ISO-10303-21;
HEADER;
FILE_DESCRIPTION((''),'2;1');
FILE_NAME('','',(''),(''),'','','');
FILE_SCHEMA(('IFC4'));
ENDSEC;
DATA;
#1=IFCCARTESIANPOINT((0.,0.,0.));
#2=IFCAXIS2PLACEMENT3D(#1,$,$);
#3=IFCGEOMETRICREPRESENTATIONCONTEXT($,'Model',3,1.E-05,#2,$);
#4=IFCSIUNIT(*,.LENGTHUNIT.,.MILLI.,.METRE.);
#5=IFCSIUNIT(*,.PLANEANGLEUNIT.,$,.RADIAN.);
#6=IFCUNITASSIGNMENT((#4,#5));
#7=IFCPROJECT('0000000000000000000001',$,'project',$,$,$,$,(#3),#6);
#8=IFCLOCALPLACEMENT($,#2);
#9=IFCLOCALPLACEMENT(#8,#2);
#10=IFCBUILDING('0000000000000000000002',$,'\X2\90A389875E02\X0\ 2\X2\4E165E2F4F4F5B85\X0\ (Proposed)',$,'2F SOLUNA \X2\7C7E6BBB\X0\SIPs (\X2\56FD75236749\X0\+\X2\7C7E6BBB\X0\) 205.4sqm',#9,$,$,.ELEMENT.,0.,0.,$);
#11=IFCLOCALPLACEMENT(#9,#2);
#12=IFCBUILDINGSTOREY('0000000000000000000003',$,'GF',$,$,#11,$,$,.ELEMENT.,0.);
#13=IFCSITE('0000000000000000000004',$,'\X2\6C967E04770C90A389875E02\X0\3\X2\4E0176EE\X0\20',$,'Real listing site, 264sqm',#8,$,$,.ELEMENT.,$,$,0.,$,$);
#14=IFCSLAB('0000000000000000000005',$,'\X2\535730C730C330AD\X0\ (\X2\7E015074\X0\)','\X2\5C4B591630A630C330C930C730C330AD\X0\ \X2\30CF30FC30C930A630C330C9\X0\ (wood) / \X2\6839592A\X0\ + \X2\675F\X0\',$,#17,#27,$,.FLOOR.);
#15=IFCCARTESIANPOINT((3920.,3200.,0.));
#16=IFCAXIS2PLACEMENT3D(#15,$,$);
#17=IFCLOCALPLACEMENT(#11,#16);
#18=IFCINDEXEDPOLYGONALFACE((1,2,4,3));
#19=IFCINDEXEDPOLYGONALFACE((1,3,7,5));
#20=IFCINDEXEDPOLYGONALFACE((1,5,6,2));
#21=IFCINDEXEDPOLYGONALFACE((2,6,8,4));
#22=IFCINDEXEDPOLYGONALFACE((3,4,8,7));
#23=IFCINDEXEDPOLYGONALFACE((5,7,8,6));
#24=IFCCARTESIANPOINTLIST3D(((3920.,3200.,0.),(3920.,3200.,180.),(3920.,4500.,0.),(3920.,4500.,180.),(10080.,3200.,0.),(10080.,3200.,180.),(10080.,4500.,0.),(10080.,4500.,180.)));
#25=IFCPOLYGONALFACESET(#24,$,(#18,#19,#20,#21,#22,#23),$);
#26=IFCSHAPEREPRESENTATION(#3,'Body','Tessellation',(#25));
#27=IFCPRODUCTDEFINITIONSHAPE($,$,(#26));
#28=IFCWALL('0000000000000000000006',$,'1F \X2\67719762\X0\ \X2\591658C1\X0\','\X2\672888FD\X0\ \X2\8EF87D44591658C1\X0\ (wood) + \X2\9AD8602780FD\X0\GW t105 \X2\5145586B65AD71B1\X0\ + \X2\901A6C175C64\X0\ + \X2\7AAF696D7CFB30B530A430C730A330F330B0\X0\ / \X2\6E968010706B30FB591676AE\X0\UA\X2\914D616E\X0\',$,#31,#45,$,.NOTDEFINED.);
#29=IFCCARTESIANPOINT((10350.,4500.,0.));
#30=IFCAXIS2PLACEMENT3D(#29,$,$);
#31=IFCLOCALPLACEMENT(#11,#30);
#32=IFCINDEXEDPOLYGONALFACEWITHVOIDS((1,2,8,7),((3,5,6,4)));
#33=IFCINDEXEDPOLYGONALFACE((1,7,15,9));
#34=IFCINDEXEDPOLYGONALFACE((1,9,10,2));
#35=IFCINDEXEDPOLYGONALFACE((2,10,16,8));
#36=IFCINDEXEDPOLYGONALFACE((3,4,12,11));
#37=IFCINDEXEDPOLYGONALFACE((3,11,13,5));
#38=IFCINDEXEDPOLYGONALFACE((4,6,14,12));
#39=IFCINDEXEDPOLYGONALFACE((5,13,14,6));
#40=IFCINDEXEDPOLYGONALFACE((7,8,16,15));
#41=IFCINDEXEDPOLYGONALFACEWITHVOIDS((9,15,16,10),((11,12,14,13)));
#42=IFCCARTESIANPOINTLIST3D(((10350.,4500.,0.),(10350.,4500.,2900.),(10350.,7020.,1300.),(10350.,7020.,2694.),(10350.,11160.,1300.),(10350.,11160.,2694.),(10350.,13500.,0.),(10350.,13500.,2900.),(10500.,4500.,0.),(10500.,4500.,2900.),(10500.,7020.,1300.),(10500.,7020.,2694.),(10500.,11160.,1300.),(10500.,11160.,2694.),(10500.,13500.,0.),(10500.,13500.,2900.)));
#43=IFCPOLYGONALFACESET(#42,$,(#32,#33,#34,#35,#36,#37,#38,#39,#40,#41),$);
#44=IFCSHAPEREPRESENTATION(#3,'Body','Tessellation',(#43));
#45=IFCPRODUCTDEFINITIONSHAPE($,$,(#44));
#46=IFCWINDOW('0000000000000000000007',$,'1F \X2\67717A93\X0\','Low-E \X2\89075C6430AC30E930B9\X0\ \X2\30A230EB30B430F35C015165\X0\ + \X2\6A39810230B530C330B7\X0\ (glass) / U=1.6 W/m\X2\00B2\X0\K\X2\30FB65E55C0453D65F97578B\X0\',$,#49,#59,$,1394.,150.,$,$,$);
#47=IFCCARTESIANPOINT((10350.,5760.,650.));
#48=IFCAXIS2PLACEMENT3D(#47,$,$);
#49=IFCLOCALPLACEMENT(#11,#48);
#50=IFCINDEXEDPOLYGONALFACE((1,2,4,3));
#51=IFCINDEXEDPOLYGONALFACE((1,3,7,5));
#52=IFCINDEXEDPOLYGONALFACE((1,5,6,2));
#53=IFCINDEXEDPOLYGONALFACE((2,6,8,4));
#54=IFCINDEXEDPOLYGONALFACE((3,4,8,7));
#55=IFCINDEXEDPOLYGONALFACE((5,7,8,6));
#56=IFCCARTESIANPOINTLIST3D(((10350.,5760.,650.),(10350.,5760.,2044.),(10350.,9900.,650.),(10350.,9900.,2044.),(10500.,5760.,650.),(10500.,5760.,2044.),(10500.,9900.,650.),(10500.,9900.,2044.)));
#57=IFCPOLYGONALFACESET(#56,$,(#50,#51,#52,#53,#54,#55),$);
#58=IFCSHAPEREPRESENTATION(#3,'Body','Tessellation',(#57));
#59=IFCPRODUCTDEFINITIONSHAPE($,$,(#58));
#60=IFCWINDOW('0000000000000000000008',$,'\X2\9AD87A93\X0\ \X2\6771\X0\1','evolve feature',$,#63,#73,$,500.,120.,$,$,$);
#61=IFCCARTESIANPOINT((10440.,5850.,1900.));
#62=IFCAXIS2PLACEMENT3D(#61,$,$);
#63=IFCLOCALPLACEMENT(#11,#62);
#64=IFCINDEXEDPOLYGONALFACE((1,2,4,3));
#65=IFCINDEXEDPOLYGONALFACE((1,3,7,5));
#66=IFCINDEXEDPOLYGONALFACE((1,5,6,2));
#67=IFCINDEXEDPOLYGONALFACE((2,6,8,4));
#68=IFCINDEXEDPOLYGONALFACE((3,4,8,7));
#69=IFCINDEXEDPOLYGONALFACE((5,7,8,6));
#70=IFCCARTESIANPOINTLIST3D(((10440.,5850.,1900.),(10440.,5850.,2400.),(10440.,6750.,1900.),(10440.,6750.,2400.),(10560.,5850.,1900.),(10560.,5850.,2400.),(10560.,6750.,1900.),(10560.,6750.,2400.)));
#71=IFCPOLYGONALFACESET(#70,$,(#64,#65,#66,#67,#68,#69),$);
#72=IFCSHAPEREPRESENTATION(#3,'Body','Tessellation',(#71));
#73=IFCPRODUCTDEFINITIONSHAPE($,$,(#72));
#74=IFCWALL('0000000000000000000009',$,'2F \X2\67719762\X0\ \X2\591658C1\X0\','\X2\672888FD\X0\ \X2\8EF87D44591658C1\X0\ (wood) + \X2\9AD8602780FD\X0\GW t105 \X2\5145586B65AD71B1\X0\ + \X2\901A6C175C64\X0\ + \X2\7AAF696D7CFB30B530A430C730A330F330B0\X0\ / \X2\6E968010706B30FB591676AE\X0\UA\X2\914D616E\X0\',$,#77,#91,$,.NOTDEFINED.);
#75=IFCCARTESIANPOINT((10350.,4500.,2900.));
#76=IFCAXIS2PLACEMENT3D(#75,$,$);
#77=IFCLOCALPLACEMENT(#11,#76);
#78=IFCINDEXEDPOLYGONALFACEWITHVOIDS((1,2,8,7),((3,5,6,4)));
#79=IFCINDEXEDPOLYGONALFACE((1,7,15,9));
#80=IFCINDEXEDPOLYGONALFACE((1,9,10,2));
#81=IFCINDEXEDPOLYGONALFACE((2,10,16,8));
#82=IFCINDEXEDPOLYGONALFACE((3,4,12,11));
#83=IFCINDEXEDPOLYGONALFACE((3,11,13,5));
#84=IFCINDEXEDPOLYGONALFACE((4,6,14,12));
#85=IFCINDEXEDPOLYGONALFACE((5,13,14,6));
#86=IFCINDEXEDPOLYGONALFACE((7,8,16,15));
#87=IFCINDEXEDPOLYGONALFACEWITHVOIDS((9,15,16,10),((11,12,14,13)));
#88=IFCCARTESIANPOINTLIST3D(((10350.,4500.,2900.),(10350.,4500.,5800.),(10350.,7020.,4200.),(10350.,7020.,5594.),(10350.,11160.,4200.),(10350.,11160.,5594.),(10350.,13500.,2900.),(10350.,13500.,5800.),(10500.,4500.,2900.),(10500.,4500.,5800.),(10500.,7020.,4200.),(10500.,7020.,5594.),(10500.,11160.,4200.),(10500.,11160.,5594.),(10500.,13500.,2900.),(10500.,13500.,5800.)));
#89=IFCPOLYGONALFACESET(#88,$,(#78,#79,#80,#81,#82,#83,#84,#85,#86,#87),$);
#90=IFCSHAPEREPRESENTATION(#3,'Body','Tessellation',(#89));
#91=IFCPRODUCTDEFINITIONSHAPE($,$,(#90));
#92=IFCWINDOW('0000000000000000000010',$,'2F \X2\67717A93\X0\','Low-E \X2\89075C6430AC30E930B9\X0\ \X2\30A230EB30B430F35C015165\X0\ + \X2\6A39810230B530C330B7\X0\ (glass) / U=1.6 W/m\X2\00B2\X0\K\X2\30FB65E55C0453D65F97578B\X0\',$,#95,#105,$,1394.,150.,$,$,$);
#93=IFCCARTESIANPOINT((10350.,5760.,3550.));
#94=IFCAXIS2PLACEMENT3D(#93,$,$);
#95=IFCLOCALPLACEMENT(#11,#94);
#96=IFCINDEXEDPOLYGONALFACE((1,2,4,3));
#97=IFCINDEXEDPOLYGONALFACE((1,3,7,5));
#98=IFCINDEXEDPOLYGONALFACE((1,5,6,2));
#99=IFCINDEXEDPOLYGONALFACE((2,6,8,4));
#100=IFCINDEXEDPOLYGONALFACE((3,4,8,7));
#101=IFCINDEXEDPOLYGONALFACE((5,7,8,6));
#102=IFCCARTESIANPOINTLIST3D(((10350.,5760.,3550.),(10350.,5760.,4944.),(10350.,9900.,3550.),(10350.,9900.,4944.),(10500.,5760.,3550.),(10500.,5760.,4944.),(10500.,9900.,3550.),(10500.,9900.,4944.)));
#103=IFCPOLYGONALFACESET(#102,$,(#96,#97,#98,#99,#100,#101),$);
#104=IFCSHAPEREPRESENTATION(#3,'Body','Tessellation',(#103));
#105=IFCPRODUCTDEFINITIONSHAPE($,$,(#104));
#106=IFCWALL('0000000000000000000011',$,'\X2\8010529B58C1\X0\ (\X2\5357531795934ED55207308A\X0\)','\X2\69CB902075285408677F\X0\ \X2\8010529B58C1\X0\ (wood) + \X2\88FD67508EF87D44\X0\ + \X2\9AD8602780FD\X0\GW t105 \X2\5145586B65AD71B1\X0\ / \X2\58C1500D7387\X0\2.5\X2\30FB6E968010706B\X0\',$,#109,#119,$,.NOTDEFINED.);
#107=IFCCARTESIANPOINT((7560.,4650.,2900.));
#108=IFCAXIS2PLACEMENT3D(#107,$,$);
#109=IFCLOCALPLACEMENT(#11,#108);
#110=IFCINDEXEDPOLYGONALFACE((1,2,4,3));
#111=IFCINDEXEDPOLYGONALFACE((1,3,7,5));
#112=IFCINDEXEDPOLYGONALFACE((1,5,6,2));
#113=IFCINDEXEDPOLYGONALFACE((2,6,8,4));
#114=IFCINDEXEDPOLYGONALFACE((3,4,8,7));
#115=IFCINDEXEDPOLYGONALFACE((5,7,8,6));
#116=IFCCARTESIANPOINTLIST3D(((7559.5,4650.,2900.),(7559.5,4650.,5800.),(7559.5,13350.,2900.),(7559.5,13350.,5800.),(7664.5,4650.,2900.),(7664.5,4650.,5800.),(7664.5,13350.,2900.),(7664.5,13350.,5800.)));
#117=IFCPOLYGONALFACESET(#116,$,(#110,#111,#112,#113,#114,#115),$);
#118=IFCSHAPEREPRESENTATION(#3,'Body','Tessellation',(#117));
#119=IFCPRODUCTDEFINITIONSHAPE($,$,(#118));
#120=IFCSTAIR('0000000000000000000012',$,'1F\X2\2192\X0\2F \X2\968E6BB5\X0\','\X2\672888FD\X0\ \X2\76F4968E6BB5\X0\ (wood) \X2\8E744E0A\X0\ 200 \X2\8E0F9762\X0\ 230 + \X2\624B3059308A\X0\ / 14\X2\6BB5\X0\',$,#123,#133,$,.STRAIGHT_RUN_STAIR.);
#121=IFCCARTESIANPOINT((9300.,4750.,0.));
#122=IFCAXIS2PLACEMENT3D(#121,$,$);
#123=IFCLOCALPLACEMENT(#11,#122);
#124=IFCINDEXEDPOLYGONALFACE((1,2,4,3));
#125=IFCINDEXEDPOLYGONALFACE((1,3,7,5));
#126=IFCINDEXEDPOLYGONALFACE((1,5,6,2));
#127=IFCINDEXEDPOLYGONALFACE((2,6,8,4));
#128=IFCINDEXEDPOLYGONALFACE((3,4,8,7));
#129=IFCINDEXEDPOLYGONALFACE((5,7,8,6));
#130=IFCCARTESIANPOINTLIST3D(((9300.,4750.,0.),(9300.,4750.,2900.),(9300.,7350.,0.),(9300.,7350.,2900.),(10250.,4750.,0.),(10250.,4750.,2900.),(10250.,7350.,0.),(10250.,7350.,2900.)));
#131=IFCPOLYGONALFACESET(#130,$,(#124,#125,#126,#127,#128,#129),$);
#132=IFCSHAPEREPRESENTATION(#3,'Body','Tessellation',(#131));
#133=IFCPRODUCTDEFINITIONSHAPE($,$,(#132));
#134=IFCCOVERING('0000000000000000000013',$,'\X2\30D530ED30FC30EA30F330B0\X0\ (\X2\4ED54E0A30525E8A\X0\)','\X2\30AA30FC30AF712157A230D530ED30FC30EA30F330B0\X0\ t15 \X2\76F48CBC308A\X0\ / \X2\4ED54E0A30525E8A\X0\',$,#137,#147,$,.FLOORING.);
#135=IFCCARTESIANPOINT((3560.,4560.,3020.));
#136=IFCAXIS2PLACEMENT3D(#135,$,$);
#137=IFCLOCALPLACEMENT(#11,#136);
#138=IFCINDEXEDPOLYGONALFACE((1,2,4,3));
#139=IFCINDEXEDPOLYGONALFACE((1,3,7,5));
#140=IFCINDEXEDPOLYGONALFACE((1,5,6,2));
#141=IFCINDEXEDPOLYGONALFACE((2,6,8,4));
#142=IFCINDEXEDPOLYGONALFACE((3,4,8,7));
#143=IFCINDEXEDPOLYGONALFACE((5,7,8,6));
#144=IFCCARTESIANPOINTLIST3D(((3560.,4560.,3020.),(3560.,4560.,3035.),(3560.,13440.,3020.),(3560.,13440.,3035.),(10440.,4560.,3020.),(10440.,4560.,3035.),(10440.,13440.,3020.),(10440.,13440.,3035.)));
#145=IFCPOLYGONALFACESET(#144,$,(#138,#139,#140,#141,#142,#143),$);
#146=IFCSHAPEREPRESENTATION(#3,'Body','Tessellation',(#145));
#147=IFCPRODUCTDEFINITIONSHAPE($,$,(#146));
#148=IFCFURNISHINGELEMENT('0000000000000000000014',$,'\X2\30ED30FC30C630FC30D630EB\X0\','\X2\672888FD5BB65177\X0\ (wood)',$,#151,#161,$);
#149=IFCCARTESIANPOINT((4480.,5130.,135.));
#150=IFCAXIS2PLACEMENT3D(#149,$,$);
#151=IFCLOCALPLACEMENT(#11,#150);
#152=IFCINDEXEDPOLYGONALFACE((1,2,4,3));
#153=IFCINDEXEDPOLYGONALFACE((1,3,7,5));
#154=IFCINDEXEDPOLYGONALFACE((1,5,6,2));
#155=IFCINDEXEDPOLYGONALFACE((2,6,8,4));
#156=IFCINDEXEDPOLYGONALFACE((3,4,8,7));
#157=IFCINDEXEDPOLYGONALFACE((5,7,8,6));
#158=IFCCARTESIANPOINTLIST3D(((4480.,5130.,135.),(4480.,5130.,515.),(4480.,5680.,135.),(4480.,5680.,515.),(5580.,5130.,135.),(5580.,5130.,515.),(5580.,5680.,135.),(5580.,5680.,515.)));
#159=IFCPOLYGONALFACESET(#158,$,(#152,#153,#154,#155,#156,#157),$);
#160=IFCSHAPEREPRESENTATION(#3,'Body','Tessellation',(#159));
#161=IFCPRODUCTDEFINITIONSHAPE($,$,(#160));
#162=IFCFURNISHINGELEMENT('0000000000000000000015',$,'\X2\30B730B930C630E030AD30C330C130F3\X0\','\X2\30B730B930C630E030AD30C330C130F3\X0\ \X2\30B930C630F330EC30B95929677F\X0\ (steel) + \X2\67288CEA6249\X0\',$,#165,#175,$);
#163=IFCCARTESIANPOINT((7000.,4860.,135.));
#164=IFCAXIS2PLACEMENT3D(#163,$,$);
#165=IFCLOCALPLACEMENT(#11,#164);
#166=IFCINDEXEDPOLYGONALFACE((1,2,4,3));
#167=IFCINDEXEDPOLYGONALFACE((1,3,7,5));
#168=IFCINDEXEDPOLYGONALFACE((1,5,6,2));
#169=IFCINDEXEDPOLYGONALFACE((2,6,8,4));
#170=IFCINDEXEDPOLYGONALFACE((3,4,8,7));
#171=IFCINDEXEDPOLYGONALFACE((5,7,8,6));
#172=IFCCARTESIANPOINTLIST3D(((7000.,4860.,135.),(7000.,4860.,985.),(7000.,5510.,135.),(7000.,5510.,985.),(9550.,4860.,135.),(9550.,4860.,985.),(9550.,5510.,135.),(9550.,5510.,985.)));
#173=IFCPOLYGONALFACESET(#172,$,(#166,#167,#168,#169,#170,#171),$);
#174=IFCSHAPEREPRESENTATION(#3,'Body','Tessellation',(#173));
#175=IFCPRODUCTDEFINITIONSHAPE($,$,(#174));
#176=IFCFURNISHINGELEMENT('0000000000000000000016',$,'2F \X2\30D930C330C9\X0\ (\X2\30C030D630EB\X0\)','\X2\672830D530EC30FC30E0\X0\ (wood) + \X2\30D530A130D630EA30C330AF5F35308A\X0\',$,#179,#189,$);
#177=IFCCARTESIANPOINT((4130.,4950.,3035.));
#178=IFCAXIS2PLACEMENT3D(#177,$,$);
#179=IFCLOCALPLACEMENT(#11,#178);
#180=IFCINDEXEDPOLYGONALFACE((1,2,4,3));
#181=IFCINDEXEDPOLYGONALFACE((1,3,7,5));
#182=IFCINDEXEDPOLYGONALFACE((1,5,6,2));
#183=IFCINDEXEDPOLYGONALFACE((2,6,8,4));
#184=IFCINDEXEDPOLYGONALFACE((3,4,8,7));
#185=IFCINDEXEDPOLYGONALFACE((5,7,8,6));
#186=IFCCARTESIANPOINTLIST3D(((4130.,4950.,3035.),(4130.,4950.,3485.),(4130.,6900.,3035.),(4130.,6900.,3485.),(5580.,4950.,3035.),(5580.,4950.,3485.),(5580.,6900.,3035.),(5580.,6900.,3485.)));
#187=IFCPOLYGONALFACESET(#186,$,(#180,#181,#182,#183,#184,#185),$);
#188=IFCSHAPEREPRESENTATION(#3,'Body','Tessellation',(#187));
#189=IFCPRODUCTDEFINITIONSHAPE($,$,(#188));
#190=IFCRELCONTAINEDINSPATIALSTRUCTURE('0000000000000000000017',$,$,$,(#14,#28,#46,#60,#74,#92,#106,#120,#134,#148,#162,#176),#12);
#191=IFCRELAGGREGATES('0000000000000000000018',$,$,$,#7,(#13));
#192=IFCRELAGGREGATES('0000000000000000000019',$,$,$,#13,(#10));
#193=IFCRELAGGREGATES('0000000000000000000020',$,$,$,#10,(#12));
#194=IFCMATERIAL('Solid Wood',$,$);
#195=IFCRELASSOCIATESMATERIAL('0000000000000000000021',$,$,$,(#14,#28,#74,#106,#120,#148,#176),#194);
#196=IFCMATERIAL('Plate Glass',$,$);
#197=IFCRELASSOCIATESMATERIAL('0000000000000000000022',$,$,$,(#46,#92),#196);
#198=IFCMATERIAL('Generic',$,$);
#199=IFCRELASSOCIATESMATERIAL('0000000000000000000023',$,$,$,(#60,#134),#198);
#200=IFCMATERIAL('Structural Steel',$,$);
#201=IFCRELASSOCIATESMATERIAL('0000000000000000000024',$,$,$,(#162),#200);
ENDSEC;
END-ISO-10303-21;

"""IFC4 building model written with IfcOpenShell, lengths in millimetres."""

from ifc_helpers import new_model, si_unit, frame, frame_2d, origin, place, context, project, spatial, rectangle, extrude, material, element, fill, save


model = new_model("IFC4")

# Units and contexts
model_context = context("Model", 3, precision=1e-05, world=origin())
ifc_project = project(units=[si_unit("LENGTHUNIT", "METRE", prefix="MILLI"), si_unit("PLANEANGLEUNIT", "RADIAN")], contexts=[model_context])

# Site, building, storey
site_placement = place(None, origin())
site = spatial("IfcSite", under=ifc_project, at=site_placement, Name="沖縄県那覇市3丁目20", ObjectType="Real listing site, 264sqm", CompositionType="ELEMENT", RefElevation=0.0)
building_placement = place(site_placement, origin())
building = spatial("IfcBuilding", under=site, at=building_placement, Name="那覇市 2世帯住宅 (Proposed)", ObjectType="2F SOLUNA 籾殻SIPs (国産杉+籾殻) 205.4sqm", CompositionType="ELEMENT", ElevationOfRefHeight=0.0, ElevationOfTerrain=0.0)
storey_placement = place(building_placement, origin())
storey = spatial("IfcBuildingStorey", under=building, at=storey_placement, Name="GF", CompositionType="ELEMENT", Elevation=0.0)

# Slab
ifc_material_1 = material(Name="Solid Wood")
slab_placement = place(storey_placement, frame((3920.0, 3200.0, 0.0)))
element("IfcSlab", 1, at=slab_placement, inside=storey, material=ifc_material_1, Name="南デッキ (縁側)", Description="屋外ウッドデッキ ハードウッド (wood) / 根太 + 束", PredefinedType="FLOOR", context=model_context, shape_type="SweptSolid", body=[
    extrude(rectangle(XDim=6160.0, YDim=1300.0, at=frame_2d((3080.0, 650.0))), frame((3920.0, 3200.0, 0.0)), (0.0, 0.0, 1.0), 180.0),
])

# Wall, openings, windows
wall_1_placement = place(storey_placement, frame((10350.0, 4500.0, 0.0)))
wall_1 = element("IfcWall", 2, at=wall_1_placement, inside=storey, material=ifc_material_1, Name="1F 東面 外壁", Description="木製 軸組外壁 (wood) + 高性能GW t105 充填断熱 + 通気層 + 窯業系サイディング / 準耐火・外皮UA配慮", PredefinedType="NOTDEFINED", context=model_context, shape_type="SweptSolid", body=[
    extrude(rectangle(XDim=150.0, YDim=9000.0, at=frame_2d((75.0, 4500.0))), frame((10350.0, 4500.0, 0.0)), (0.0, 0.0, 1.0), 2900.0),
])
opening_1_placement = place(storey_placement, frame((10350.0, 5760.0, 650.0)))
opening_1 = element("IfcOpeningElement", 3, at=opening_1_placement, cuts=wall_1, PredefinedType="NOTDEFINED", context=model_context, shape_type="SweptSolid", body=[
    extrude(rectangle(XDim=150.0, YDim=4140.0, at=frame_2d((75.0, 2070.0))), frame((10350.0, 5760.0, 650.0)), (0.0, 0.0, 1.0), 1394.0),
])
opening_2_placement = place(storey_placement, frame((10440.0, 5850.0, 1900.0)))
opening_2 = element("IfcOpeningElement", 4, at=opening_2_placement, cuts=wall_1, PredefinedType="NOTDEFINED", context=model_context, shape_type="SweptSolid", body=[
    extrude(rectangle(XDim=120.0, YDim=900.0, at=frame_2d((60.0, 450.0))), frame((10440.0, 5850.0, 1900.0)), (0.0, 0.0, 1.0), 500.0),
])
ifc_material_2 = material(Name="Plate Glass")
window_1_placement = place(storey_placement, frame((10350.0, 5760.0, 650.0)))
window_1 = element("IfcWindow", 5, at=window_1_placement, inside=storey, material=ifc_material_2, Name="1F 東窓", Description="Low-E 複層ガラス アルゴン封入 + 樹脂サッシ (glass) / U=1.6 W/m²K・日射取得型", OverallHeight=1394.0, OverallWidth=150.0, context=model_context, shape_type="SweptSolid", body=[
    extrude(rectangle(XDim=150.0, YDim=4140.0, at=frame_2d((75.0, 2070.0))), frame((10350.0, 5760.0, 650.0)), (0.0, 0.0, 1.0), 1394.0),
])
fill(opening_1, window_1)
ifc_material_3 = material(Name="Generic")
window_2_placement = place(storey_placement, frame((10440.0, 5850.0, 1900.0)))
window_2 = element("IfcWindow", 6, at=window_2_placement, inside=storey, material=ifc_material_3, Name="高窓 東1", Description="evolve feature", OverallHeight=500.0, OverallWidth=120.0, context=model_context, shape_type="SweptSolid", body=[
    extrude(rectangle(XDim=120.0, YDim=900.0, at=frame_2d((60.0, 450.0))), frame((10440.0, 5850.0, 1900.0)), (0.0, 0.0, 1.0), 500.0),
])
fill(opening_2, window_2)

# Wall, opening, window
wall_2_placement = place(storey_placement, frame((10350.0, 4500.0, 2900.0)))
wall_2 = element("IfcWall", 7, at=wall_2_placement, inside=storey, material=ifc_material_1, Name="2F 東面 外壁", Description="木製 軸組外壁 (wood) + 高性能GW t105 充填断熱 + 通気層 + 窯業系サイディング / 準耐火・外皮UA配慮", PredefinedType="NOTDEFINED", context=model_context, shape_type="SweptSolid", body=[
    extrude(rectangle(XDim=150.0, YDim=9000.0, at=frame_2d((75.0, 4500.0))), frame((10350.0, 4500.0, 2900.0)), (0.0, 0.0, 1.0), 2900.0),
])
opening_3_placement = place(storey_placement, frame((10350.0, 5760.0, 3550.0)))
opening_3 = element("IfcOpeningElement", 8, at=opening_3_placement, cuts=wall_2, PredefinedType="NOTDEFINED", context=model_context, shape_type="SweptSolid", body=[
    extrude(rectangle(XDim=150.0, YDim=4140.0, at=frame_2d((75.0, 2070.0))), frame((10350.0, 5760.0, 3550.0)), (0.0, 0.0, 1.0), 1394.0),
])
window_3_placement = place(storey_placement, frame((10350.0, 5760.0, 3550.0)))
window_3 = element("IfcWindow", 9, at=window_3_placement, inside=storey, material=ifc_material_2, Name="2F 東窓", Description="Low-E 複層ガラス アルゴン封入 + 樹脂サッシ (glass) / U=1.6 W/m²K・日射取得型", OverallHeight=1394.0, OverallWidth=150.0, context=model_context, shape_type="SweptSolid", body=[
    extrude(rectangle(XDim=150.0, YDim=4140.0, at=frame_2d((75.0, 2070.0))), frame((10350.0, 5760.0, 3550.0)), (0.0, 0.0, 1.0), 1394.0),
])
fill(opening_3, window_3)

# Wall
wall_3_placement = place(storey_placement, frame((7560.0, 4650.0, 2900.0)))
element("IfcWall", 10, at=wall_3_placement, inside=storey, material=ifc_material_1, Name="耐力壁 (南北間仕切り)", Description="構造用合板 耐力壁 (wood) + 製材軸組 + 高性能GW t105 充填断熱 / 壁倍率2.5・準耐火", PredefinedType="NOTDEFINED", context=model_context, shape_type="SweptSolid", body=[
    extrude(rectangle(XDim=105.0, YDim=8700.0, at=frame_2d((52.0, 4350.0))), frame((7560.0, 4650.0, 2900.0)), (0.0, 0.0, 1.0), 2900.0),
])

# Stair
stair_placement = place(storey_placement, frame((9300.0, 4750.0, 0.0)))
element("IfcStair", 11, at=stair_placement, inside=storey, material=ifc_material_1, Name="1F→2F 階段", Description="木製 直階段 (wood) 蹴上 200 踏面 230 + 手すり / 14段", PredefinedType="STRAIGHT_RUN_STAIR", context=model_context, shape_type="SweptSolid", body=[
    extrude(rectangle(XDim=950.0, YDim=2600.0, at=frame_2d((475.0, 1300.0))), frame((9300.0, 4750.0, 0.0)), (0.0, 0.0, 1.0), 2900.0),
])

# Covering
covering_placement = place(storey_placement, frame((3560.0, 4560.0, 3020.0)))
element("IfcCovering", 12, at=covering_placement, inside=storey, material=ifc_material_3, Name="フローリング (仕上げ床)", Description="オーク無垢フローリング t15 直貼り / 仕上げ床", PredefinedType="FLOORING", context=model_context, shape_type="SweptSolid", body=[
    extrude(rectangle(XDim=6880.0, YDim=8880.0, at=frame_2d((3440.0, 4440.0))), frame((3560.0, 4560.0, 3020.0)), (0.0, 0.0, 1.0), 15.0),
])

# Furnishing elements
furnishing_1_placement = place(storey_placement, frame((4480.0, 5130.0, 135.0)))
element("IfcFurnishingElement", 13, at=furnishing_1_placement, inside=storey, material=ifc_material_1, Name="ローテーブル", Description="木製家具 (wood)", context=model_context, shape_type="SweptSolid", body=[
    extrude(rectangle(XDim=1100.0, YDim=550.0, at=frame_2d((550.0, 275.0))), frame((4480.0, 5130.0, 135.0)), (0.0, 0.0, 1.0), 380.0),
])
ifc_material_4 = material(Name="Structural Steel")
furnishing_2_placement = place(storey_placement, frame((7000.0, 4860.0, 135.0)))
element("IfcFurnishingElement", 14, at=furnishing_2_placement, inside=storey, material=ifc_material_4, Name="システムキッチン", Description="システムキッチン ステンレス天板 (steel) + 木質扉", context=model_context, shape_type="SweptSolid", body=[
    extrude(rectangle(XDim=2550.0, YDim=650.0, at=frame_2d((1275.0, 325.0))), frame((7000.0, 4860.0, 135.0)), (0.0, 0.0, 1.0), 850.0),
])
furnishing_3_placement = place(storey_placement, frame((4130.0, 4950.0, 3035.0)))
element("IfcFurnishingElement", 15, at=furnishing_3_placement, inside=storey, material=ifc_material_1, Name="2F ベッド (ダブル)", Description="木フレーム (wood) + ファブリック張り", context=model_context, shape_type="SweptSolid", body=[
    extrude(rectangle(XDim=1450.0, YDim=1950.0, at=frame_2d((725.0, 975.0))), frame((4130.0, 4950.0, 3035.0)), (0.0, 0.0, 1.0), 450.0),
])

save(model, "model.ifc")
